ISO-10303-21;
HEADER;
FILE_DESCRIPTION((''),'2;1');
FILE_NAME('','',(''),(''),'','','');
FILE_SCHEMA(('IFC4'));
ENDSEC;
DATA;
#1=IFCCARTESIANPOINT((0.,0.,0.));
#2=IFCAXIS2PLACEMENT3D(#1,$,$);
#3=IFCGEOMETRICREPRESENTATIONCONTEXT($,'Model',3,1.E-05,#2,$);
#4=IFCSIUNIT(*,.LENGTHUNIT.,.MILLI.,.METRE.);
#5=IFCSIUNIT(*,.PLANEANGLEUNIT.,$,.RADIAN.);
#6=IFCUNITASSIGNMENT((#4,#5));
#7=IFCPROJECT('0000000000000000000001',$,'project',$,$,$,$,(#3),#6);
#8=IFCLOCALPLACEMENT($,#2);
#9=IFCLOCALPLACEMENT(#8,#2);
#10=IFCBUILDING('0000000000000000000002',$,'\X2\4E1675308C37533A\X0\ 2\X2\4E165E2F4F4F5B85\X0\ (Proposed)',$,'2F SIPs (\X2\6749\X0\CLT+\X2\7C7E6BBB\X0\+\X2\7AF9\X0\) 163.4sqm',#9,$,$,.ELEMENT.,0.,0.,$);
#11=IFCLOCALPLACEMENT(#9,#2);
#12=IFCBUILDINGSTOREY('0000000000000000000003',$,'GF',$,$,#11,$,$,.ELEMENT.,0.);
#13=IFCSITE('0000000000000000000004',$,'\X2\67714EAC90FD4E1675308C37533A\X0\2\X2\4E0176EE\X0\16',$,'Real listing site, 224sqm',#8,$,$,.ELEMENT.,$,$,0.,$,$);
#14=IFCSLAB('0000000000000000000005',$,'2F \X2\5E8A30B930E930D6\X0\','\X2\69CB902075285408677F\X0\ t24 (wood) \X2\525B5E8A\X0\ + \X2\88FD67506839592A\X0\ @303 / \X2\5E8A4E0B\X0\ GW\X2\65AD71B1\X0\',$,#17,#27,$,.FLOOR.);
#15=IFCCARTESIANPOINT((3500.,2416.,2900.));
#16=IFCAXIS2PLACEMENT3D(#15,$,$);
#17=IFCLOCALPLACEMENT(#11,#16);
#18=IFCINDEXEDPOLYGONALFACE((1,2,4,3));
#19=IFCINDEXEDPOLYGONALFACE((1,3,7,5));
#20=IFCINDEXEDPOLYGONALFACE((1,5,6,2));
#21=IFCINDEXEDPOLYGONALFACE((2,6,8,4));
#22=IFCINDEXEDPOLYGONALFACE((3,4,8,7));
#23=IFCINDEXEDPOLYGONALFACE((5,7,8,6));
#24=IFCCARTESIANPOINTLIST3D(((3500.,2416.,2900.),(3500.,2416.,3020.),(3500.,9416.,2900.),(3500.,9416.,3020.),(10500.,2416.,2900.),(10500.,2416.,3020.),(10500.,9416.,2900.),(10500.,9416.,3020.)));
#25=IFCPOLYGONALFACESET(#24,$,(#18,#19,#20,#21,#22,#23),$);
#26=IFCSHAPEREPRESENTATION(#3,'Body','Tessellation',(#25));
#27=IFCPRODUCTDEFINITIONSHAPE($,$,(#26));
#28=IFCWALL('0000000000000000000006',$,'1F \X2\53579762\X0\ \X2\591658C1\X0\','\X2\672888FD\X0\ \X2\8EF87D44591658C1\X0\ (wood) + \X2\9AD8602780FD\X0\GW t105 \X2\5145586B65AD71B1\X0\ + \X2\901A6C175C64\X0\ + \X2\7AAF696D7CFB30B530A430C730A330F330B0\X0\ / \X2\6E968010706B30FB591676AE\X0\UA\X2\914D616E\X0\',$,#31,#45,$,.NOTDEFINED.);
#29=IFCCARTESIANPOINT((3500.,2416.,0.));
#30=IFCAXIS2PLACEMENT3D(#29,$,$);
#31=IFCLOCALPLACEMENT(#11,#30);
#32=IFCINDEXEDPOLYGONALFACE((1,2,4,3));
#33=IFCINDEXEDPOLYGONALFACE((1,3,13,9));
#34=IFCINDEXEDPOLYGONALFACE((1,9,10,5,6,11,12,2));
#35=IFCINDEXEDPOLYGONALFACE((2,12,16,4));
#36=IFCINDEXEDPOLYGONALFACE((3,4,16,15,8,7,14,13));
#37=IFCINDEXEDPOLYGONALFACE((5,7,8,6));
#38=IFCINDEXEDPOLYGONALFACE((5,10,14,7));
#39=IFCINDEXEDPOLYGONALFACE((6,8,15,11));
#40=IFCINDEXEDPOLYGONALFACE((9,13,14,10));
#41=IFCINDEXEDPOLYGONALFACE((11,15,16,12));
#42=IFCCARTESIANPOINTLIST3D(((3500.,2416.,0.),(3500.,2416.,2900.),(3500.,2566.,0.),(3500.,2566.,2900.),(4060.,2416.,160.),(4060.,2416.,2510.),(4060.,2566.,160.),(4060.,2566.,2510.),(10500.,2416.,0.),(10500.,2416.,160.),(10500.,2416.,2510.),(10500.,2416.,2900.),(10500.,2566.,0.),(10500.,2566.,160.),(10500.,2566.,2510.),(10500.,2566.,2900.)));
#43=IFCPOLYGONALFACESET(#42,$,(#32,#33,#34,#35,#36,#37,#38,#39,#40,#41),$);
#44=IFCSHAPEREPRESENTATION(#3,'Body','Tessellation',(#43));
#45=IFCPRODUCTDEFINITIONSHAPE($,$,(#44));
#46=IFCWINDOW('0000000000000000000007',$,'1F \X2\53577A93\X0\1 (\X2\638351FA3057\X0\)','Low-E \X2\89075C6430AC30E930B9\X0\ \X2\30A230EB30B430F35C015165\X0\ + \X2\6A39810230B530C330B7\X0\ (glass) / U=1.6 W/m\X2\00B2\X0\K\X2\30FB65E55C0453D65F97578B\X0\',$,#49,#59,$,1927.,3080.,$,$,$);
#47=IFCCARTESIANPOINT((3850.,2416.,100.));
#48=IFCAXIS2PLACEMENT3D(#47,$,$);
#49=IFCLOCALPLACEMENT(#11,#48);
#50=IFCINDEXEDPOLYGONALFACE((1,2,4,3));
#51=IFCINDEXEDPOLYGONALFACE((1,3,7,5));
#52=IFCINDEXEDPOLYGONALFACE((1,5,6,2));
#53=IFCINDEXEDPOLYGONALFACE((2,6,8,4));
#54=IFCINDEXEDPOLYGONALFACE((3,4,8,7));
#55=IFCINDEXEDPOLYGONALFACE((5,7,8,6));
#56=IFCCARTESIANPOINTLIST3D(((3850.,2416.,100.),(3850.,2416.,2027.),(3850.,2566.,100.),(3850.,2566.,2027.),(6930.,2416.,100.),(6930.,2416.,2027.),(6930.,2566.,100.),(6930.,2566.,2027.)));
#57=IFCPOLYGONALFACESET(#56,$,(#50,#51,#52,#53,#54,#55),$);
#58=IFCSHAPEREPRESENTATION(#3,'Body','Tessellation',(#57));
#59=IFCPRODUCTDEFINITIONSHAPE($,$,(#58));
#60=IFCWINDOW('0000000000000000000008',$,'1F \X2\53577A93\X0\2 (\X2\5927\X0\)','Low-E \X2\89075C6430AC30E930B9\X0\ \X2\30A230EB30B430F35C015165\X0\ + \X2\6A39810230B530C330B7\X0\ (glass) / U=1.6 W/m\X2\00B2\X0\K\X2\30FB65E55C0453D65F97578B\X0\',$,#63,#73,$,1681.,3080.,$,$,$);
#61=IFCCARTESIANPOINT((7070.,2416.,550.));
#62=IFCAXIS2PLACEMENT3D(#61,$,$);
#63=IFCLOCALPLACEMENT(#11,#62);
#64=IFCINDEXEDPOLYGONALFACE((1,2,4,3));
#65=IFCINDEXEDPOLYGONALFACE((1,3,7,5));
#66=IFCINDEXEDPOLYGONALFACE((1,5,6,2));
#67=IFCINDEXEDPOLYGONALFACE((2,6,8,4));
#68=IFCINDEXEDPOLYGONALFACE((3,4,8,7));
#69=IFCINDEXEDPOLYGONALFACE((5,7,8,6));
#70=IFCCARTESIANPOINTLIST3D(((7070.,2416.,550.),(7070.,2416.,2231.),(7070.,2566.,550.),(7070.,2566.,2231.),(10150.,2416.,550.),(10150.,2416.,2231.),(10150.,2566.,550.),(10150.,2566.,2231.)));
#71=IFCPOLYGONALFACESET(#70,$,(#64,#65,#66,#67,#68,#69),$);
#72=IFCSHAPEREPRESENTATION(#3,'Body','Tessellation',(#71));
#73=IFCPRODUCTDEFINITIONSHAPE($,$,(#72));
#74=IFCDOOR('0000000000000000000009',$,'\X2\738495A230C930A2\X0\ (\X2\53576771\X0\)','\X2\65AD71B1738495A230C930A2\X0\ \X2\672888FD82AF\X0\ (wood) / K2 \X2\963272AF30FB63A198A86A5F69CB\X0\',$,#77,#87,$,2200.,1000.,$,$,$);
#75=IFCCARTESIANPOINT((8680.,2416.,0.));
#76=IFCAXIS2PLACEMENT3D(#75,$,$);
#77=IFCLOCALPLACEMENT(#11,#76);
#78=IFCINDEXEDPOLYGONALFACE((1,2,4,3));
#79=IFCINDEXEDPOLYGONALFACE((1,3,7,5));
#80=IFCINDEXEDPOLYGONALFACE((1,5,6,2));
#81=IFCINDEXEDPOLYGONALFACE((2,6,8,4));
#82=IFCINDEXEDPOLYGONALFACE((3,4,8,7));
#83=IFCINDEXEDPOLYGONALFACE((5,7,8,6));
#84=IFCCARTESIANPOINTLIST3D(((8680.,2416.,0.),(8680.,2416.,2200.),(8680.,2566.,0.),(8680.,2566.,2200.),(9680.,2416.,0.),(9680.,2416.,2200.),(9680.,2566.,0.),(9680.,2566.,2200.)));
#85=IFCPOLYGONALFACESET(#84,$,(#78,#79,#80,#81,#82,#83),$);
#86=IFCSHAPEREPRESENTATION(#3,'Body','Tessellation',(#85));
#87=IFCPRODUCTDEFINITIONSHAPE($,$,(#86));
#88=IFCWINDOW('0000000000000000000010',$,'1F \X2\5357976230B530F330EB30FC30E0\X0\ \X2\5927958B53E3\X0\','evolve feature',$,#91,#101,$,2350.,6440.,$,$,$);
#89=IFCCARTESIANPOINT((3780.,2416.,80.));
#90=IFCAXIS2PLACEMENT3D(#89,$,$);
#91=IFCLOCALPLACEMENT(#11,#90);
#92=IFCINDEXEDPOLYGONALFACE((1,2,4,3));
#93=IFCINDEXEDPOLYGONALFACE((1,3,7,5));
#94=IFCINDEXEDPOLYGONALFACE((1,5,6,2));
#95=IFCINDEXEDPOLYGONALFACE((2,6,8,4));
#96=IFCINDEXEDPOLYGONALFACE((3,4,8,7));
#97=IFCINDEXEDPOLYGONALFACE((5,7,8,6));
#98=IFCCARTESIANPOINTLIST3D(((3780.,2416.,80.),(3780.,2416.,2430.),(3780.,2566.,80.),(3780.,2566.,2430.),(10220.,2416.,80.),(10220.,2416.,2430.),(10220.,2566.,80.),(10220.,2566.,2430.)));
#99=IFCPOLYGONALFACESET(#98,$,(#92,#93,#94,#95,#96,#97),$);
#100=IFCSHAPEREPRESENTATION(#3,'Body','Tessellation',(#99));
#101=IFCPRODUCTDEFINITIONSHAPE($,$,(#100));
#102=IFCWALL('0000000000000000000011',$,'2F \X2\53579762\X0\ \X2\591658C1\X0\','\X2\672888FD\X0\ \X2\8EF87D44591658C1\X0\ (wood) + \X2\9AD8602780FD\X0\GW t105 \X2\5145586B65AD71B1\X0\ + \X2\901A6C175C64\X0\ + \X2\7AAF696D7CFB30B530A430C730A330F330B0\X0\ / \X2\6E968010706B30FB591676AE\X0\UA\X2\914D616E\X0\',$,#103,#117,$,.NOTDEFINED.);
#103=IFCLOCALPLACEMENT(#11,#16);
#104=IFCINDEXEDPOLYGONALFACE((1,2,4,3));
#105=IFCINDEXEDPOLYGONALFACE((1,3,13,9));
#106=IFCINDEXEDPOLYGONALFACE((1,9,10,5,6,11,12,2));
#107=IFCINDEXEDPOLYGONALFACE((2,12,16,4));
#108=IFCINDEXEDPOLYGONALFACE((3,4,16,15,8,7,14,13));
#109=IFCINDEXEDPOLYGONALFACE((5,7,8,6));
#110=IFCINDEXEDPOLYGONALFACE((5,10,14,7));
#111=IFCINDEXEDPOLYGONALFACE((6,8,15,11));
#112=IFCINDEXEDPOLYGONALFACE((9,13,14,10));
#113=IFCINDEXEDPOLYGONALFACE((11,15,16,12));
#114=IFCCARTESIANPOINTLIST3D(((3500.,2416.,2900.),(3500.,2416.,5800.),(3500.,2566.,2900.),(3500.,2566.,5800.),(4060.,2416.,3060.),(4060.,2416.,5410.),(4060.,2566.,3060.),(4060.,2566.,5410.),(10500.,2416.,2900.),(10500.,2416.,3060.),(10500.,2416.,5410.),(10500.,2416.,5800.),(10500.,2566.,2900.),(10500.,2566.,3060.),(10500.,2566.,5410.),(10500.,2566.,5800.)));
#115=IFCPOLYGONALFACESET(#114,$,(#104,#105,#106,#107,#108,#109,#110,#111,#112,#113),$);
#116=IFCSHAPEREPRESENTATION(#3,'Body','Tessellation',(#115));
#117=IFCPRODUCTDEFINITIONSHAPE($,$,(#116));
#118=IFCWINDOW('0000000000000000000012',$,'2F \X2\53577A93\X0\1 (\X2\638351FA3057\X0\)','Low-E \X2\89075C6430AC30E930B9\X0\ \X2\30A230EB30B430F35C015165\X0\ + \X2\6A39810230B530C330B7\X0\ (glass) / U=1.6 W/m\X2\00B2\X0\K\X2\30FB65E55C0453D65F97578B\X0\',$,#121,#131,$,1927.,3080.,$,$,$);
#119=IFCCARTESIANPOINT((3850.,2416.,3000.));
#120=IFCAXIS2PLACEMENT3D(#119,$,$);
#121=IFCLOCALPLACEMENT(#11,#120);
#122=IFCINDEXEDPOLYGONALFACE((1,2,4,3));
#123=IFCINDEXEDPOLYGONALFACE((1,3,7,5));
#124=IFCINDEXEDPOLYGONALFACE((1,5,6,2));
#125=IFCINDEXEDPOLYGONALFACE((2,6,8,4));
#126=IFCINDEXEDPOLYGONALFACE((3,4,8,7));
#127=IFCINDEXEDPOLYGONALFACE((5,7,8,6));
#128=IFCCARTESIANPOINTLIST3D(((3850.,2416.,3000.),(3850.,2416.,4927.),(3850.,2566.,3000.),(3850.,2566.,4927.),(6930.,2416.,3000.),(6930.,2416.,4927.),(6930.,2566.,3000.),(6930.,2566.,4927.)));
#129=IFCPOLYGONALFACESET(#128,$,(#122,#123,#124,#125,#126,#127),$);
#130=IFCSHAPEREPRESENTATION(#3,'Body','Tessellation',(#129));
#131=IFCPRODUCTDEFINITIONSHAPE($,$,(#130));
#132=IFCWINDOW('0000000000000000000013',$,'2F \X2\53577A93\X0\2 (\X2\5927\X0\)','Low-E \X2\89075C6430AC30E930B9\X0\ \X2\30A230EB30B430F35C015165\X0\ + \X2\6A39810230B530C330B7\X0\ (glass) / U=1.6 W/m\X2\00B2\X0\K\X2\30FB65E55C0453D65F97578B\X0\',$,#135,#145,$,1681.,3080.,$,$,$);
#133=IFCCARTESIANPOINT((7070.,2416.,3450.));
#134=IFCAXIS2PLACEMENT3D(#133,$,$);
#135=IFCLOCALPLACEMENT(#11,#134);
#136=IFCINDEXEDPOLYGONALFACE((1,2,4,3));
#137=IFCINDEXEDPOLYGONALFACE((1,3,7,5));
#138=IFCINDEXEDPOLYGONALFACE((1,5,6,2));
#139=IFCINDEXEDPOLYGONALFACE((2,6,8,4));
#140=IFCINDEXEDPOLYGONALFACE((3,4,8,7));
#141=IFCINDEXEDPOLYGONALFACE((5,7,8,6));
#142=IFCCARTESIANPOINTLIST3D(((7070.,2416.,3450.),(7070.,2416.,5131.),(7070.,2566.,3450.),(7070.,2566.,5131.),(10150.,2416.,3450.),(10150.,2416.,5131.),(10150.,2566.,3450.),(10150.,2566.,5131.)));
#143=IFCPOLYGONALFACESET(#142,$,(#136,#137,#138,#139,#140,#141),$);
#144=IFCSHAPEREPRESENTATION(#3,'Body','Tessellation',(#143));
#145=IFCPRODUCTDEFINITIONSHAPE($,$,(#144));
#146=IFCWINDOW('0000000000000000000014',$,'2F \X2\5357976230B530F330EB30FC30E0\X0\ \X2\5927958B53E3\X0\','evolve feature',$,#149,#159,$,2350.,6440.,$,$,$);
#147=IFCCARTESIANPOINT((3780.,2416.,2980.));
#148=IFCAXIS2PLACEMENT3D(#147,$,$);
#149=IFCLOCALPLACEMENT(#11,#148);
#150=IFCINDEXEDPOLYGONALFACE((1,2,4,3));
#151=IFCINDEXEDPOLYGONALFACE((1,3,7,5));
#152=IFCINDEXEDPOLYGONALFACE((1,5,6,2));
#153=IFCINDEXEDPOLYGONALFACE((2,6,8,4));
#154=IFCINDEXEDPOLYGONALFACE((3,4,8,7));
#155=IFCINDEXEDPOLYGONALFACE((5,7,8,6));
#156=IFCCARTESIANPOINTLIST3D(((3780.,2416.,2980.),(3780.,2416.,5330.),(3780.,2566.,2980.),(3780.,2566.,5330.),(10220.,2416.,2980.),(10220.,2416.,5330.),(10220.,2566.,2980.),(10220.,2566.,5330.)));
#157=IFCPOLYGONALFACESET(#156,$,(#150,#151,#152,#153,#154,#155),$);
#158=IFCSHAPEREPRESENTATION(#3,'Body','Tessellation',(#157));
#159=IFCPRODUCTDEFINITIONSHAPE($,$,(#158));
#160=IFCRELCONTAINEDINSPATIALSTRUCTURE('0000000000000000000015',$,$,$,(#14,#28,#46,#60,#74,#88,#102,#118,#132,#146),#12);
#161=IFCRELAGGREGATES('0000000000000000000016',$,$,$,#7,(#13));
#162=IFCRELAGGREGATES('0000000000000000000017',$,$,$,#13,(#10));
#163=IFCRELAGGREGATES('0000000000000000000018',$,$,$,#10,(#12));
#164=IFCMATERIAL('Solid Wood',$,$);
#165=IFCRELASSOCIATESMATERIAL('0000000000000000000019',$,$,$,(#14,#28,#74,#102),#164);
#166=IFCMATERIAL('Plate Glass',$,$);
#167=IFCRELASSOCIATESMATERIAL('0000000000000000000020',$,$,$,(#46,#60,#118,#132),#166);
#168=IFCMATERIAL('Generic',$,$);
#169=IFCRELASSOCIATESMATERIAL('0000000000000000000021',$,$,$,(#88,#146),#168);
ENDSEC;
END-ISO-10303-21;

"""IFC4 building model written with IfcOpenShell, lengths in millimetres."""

from ifc_helpers import new_model, si_unit, frame, frame_2d, origin, place, context, project, spatial, rectangle, extrude, material, element, fill, save


model = new_model("IFC4")

# Units and contexts
model_context = context("Model", 3, precision=1e-05, world=origin())
ifc_project = project(units=[si_unit("LENGTHUNIT", "METRE", prefix="MILLI"), si_unit("PLANEANGLEUNIT", "RADIAN")], contexts=[model_context])

# Site, building, storey
site_placement = place(None, origin())
site = spatial("IfcSite", under=ifc_project, at=site_placement, Name="東京都世田谷区2丁目16", ObjectType="Real listing site, 224sqm", CompositionType="ELEMENT", RefElevation=0.0)
building_placement = place(site_placement, origin())
building = spatial("IfcBuilding", under=site, at=building_placement, Name="世田谷区 2世帯住宅 (Proposed)", ObjectType="2F SIPs (杉CLT+籾殻+竹) 163.4sqm", CompositionType="ELEMENT", ElevationOfRefHeight=0.0, ElevationOfTerrain=0.0)
storey_placement = place(building_placement, origin())
storey = spatial("IfcBuildingStorey", under=building, at=storey_placement, Name="GF", CompositionType="ELEMENT", Elevation=0.0)

# Slab
ifc_material_1 = material(Name="Solid Wood")
slab_1_placement = place(storey_placement, frame((3500.0, 2416.0, 2900.0)))
element("IfcSlab", 1, at=slab_1_placement, inside=storey, material=ifc_material_1, Name="2F 床スラブ", Description="構造用合板 t24 (wood) 剛床 + 製材根太 @303 / 床下 GW断熱", PredefinedType="FLOOR", context=model_context, shape_type="SweptSolid", body=[
    extrude(rectangle(XDim=7000.0, YDim=7000.0, at=frame_2d((3500.0, 3500.0))), frame((3500.0, 2416.0, 2900.0)), (0.0, 0.0, 1.0), 120.0),
])
ifc_material_2 = material(Name="Generic")

# Wall, openings, windows, door
wall_1_placement = place(storey_placement, frame((3500.0, 2416.0, 0.0)))
wall_1 = element("IfcWall", 2, at=wall_1_placement, inside=storey, material=ifc_material_1, Name="1F 南面 外壁", Description="木製 軸組外壁 (wood) + 高性能GW t105 充填断熱 + 通気層 + 窯業系サイディング / 準耐火・外皮UA配慮", PredefinedType="NOTDEFINED", context=model_context, shape_type="SweptSolid", body=[
    extrude(rectangle(XDim=7000.0, YDim=150.0, at=frame_2d((3500.0, 75.0))), frame((3500.0, 2416.0, 0.0)), (0.0, 0.0, 1.0), 2900.0),
])
opening_1_placement = place(storey_placement, frame((3850.0, 2416.0, 100.0)))
opening_1 = element("IfcOpeningElement", 3, at=opening_1_placement, cuts=wall_1, PredefinedType="NOTDEFINED", context=model_context, shape_type="SweptSolid", body=[
    extrude(rectangle(XDim=3080.0, YDim=150.0, at=frame_2d((1540.0, 75.0))), frame((3850.0, 2416.0, 100.0)), (0.0, 0.0, 1.0), 1927.0),
])
opening_2_placement = place(storey_placement, frame((7070.0, 2416.0, 550.0)))
opening_2 = element("IfcOpeningElement", 4, at=opening_2_placement, cuts=wall_1, PredefinedType="NOTDEFINED", context=model_context, shape_type="SweptSolid", body=[
    extrude(rectangle(XDim=3080.0, YDim=150.0, at=frame_2d((1540.0, 75.0))), frame((7070.0, 2416.0, 550.0)), (0.0, 0.0, 1.0), 1681.0),
])
opening_3_placement = place(storey_placement, frame((8680.0, 2416.0, 0.0)))
opening_3 = element("IfcOpeningElement", 5, at=opening_3_placement, cuts=wall_1, PredefinedType="NOTDEFINED", context=model_context, shape_type="SweptSolid", body=[
    extrude(rectangle(XDim=1000.0, YDim=150.0, at=frame_2d((500.0, 75.0))), frame((8680.0, 2416.0, 0.0)), (0.0, 0.0, 1.0), 2200.0),
])
opening_4_placement = place(storey_placement, frame((3780.0, 2416.0, 80.0)))
opening_4 = element("IfcOpeningElement", 6, at=opening_4_placement, cuts=wall_1, PredefinedType="NOTDEFINED", context=model_context, shape_type="SweptSolid", body=[
    extrude(rectangle(XDim=6440.0, YDim=150.0, at=frame_2d((3220.0, 75.0))), frame((3780.0, 2416.0, 80.0)), (0.0, 0.0, 1.0), 2350.0),
])
ifc_material_3 = material(Name="Plate Glass")
window_1_placement = place(storey_placement, frame((3850.0, 2416.0, 100.0)))
window_1 = element("IfcWindow", 7, at=window_1_placement, inside=storey, material=ifc_material_3, Name="1F 南窓1 (掃出し)", Description="Low-E 複層ガラス アルゴン封入 + 樹脂サッシ (glass) / U=1.6 W/m²K・日射取得型", OverallHeight=1927.0, OverallWidth=3080.0, context=model_context, shape_type="SweptSolid", body=[
    extrude(rectangle(XDim=3080.0, YDim=150.0, at=frame_2d((1540.0, 75.0))), frame((3850.0, 2416.0, 100.0)), (0.0, 0.0, 1.0), 1927.0),
])
fill(opening_1, window_1)
window_2_placement = place(storey_placement, frame((7070.0, 2416.0, 550.0)))
window_2 = element("IfcWindow", 8, at=window_2_placement, inside=storey, material=ifc_material_3, Name="1F 南窓2 (大)", Description="Low-E 複層ガラス アルゴン封入 + 樹脂サッシ (glass) / U=1.6 W/m²K・日射取得型", OverallHeight=1681.0, OverallWidth=3080.0, context=model_context, shape_type="SweptSolid", body=[
    extrude(rectangle(XDim=3080.0, YDim=150.0, at=frame_2d((1540.0, 75.0))), frame((7070.0, 2416.0, 550.0)), (0.0, 0.0, 1.0), 1681.0),
])
fill(opening_2, window_2)
door_placement = place(storey_placement, frame((8680.0, 2416.0, 0.0)))
door = element("IfcDoor", 9, at=door_placement, inside=storey, material=ifc_material_1, Name="玄関ドア (南東)", Description="断熱玄関ドア 木製芯 (wood) / K2 防犯・採風機構", OverallHeight=2200.0, OverallWidth=1000.0, context=model_context, shape_type="SweptSolid", body=[
    extrude(rectangle(XDim=1000.0, YDim=150.0, at=frame_2d((500.0, 75.0))), frame((8680.0, 2416.0, 0.0)), (0.0, 0.0, 1.0), 2200.0),
])
fill(opening_3, door)
window_3_placement = place(storey_placement, frame((3780.0, 2416.0, 80.0)))
window_3 = element("IfcWindow", 10, at=window_3_placement, inside=storey, material=ifc_material_2, Name="1F 南面サンルーム 大開口", Description="evolve feature", OverallHeight=2350.0, OverallWidth=6440.0, context=model_context, shape_type="SweptSolid", body=[
    extrude(rectangle(XDim=6440.0, YDim=150.0, at=frame_2d((3220.0, 75.0))), frame((3780.0, 2416.0, 80.0)), (0.0, 0.0, 1.0), 2350.0),
])
fill(opening_4, window_3)

# Wall, openings, windows
wall_2_placement = place(storey_placement, frame((3500.0, 2416.0, 2900.0)))
wall_2 = element("IfcWall", 11, at=wall_2_placement, inside=storey, material=ifc_material_1, Name="2F 南面 外壁", Description="木製 軸組外壁 (wood) + 高性能GW t105 充填断熱 + 通気層 + 窯業系サイディング / 準耐火・外皮UA配慮", PredefinedType="NOTDEFINED", context=model_context, shape_type="SweptSolid", body=[
    extrude(rectangle(XDim=7000.0, YDim=150.0, at=frame_2d((3500.0, 75.0))), frame((3500.0, 2416.0, 2900.0)), (0.0, 0.0, 1.0), 2900.0),
])
opening_5_placement = place(storey_placement, frame((3850.0, 2416.0, 3000.0)))
opening_5 = element("IfcOpeningElement", 12, at=opening_5_placement, cuts=wall_2, PredefinedType="NOTDEFINED", context=model_context, shape_type="SweptSolid", body=[
    extrude(rectangle(XDim=3080.0, YDim=150.0, at=frame_2d((1540.0, 75.0))), frame((3850.0, 2416.0, 3000.0)), (0.0, 0.0, 1.0), 1927.0),
])
opening_6_placement = place(storey_placement, frame((7070.0, 2416.0, 3450.0)))
opening_6 = element("IfcOpeningElement", 13, at=opening_6_placement, cuts=wall_2, PredefinedType="NOTDEFINED", context=model_context, shape_type="SweptSolid", body=[
    extrude(rectangle(XDim=3080.0, YDim=150.0, at=frame_2d((1540.0, 75.0))), frame((7070.0, 2416.0, 3450.0)), (0.0, 0.0, 1.0), 1681.0),
])
opening_7_placement = place(storey_placement, frame((3780.0, 2416.0, 2980.0)))
opening_7 = element("IfcOpeningElement", 14, at=opening_7_placement, cuts=wall_2, PredefinedType="NOTDEFINED", context=model_context, shape_type="SweptSolid", body=[
    extrude(rectangle(XDim=6440.0, YDim=150.0, at=frame_2d((3220.0, 75.0))), frame((3780.0, 2416.0, 2980.0)), (0.0, 0.0, 1.0), 2350.0),
])
window_4_placement = place(storey_placement, frame((3850.0, 2416.0, 3000.0)))
window_4 = element("IfcWindow", 15, at=window_4_placement, inside=storey, material=ifc_material_3, Name="2F 南窓1 (掃出し)", Description="Low-E 複層ガラス アルゴン封入 + 樹脂サッシ (glass) / U=1.6 W/m²K・日射取得型", OverallHeight=1927.0, OverallWidth=3080.0, context=model_context, shape_type="SweptSolid", body=[
    extrude(rectangle(XDim=3080.0, YDim=150.0, at=frame_2d((1540.0, 75.0))), frame((3850.0, 2416.0, 3000.0)), (0.0, 0.0, 1.0), 1927.0),
])
fill(opening_5, window_4)
window_5_placement = place(storey_placement, frame((7070.0, 2416.0, 3450.0)))
window_5 = element("IfcWindow", 16, at=window_5_placement, inside=storey, material=ifc_material_3, Name="2F 南窓2 (大)", Description="Low-E 複層ガラス アルゴン封入 + 樹脂サッシ (glass) / U=1.6 W/m²K・日射取得型", OverallHeight=1681.0, OverallWidth=3080.0, context=model_context, shape_type="SweptSolid", body=[
    extrude(rectangle(XDim=3080.0, YDim=150.0, at=frame_2d((1540.0, 75.0))), frame((7070.0, 2416.0, 3450.0)), (0.0, 0.0, 1.0), 1681.0),
])
fill(opening_6, window_5)
window_6_placement = place(storey_placement, frame((3780.0, 2416.0, 2980.0)))
window_6 = element("IfcWindow", 17, at=window_6_placement, inside=storey, material=ifc_material_2, Name="2F 南面サンルーム 大開口", Description="evolve feature", OverallHeight=2350.0, OverallWidth=6440.0, context=model_context, shape_type="SweptSolid", body=[
    extrude(rectangle(XDim=6440.0, YDim=150.0, at=frame_2d((3220.0, 75.0))), frame((3780.0, 2416.0, 2980.0)), (0.0, 0.0, 1.0), 2350.0),
])
fill(opening_7, window_6)

save(model, "model.ifc")
